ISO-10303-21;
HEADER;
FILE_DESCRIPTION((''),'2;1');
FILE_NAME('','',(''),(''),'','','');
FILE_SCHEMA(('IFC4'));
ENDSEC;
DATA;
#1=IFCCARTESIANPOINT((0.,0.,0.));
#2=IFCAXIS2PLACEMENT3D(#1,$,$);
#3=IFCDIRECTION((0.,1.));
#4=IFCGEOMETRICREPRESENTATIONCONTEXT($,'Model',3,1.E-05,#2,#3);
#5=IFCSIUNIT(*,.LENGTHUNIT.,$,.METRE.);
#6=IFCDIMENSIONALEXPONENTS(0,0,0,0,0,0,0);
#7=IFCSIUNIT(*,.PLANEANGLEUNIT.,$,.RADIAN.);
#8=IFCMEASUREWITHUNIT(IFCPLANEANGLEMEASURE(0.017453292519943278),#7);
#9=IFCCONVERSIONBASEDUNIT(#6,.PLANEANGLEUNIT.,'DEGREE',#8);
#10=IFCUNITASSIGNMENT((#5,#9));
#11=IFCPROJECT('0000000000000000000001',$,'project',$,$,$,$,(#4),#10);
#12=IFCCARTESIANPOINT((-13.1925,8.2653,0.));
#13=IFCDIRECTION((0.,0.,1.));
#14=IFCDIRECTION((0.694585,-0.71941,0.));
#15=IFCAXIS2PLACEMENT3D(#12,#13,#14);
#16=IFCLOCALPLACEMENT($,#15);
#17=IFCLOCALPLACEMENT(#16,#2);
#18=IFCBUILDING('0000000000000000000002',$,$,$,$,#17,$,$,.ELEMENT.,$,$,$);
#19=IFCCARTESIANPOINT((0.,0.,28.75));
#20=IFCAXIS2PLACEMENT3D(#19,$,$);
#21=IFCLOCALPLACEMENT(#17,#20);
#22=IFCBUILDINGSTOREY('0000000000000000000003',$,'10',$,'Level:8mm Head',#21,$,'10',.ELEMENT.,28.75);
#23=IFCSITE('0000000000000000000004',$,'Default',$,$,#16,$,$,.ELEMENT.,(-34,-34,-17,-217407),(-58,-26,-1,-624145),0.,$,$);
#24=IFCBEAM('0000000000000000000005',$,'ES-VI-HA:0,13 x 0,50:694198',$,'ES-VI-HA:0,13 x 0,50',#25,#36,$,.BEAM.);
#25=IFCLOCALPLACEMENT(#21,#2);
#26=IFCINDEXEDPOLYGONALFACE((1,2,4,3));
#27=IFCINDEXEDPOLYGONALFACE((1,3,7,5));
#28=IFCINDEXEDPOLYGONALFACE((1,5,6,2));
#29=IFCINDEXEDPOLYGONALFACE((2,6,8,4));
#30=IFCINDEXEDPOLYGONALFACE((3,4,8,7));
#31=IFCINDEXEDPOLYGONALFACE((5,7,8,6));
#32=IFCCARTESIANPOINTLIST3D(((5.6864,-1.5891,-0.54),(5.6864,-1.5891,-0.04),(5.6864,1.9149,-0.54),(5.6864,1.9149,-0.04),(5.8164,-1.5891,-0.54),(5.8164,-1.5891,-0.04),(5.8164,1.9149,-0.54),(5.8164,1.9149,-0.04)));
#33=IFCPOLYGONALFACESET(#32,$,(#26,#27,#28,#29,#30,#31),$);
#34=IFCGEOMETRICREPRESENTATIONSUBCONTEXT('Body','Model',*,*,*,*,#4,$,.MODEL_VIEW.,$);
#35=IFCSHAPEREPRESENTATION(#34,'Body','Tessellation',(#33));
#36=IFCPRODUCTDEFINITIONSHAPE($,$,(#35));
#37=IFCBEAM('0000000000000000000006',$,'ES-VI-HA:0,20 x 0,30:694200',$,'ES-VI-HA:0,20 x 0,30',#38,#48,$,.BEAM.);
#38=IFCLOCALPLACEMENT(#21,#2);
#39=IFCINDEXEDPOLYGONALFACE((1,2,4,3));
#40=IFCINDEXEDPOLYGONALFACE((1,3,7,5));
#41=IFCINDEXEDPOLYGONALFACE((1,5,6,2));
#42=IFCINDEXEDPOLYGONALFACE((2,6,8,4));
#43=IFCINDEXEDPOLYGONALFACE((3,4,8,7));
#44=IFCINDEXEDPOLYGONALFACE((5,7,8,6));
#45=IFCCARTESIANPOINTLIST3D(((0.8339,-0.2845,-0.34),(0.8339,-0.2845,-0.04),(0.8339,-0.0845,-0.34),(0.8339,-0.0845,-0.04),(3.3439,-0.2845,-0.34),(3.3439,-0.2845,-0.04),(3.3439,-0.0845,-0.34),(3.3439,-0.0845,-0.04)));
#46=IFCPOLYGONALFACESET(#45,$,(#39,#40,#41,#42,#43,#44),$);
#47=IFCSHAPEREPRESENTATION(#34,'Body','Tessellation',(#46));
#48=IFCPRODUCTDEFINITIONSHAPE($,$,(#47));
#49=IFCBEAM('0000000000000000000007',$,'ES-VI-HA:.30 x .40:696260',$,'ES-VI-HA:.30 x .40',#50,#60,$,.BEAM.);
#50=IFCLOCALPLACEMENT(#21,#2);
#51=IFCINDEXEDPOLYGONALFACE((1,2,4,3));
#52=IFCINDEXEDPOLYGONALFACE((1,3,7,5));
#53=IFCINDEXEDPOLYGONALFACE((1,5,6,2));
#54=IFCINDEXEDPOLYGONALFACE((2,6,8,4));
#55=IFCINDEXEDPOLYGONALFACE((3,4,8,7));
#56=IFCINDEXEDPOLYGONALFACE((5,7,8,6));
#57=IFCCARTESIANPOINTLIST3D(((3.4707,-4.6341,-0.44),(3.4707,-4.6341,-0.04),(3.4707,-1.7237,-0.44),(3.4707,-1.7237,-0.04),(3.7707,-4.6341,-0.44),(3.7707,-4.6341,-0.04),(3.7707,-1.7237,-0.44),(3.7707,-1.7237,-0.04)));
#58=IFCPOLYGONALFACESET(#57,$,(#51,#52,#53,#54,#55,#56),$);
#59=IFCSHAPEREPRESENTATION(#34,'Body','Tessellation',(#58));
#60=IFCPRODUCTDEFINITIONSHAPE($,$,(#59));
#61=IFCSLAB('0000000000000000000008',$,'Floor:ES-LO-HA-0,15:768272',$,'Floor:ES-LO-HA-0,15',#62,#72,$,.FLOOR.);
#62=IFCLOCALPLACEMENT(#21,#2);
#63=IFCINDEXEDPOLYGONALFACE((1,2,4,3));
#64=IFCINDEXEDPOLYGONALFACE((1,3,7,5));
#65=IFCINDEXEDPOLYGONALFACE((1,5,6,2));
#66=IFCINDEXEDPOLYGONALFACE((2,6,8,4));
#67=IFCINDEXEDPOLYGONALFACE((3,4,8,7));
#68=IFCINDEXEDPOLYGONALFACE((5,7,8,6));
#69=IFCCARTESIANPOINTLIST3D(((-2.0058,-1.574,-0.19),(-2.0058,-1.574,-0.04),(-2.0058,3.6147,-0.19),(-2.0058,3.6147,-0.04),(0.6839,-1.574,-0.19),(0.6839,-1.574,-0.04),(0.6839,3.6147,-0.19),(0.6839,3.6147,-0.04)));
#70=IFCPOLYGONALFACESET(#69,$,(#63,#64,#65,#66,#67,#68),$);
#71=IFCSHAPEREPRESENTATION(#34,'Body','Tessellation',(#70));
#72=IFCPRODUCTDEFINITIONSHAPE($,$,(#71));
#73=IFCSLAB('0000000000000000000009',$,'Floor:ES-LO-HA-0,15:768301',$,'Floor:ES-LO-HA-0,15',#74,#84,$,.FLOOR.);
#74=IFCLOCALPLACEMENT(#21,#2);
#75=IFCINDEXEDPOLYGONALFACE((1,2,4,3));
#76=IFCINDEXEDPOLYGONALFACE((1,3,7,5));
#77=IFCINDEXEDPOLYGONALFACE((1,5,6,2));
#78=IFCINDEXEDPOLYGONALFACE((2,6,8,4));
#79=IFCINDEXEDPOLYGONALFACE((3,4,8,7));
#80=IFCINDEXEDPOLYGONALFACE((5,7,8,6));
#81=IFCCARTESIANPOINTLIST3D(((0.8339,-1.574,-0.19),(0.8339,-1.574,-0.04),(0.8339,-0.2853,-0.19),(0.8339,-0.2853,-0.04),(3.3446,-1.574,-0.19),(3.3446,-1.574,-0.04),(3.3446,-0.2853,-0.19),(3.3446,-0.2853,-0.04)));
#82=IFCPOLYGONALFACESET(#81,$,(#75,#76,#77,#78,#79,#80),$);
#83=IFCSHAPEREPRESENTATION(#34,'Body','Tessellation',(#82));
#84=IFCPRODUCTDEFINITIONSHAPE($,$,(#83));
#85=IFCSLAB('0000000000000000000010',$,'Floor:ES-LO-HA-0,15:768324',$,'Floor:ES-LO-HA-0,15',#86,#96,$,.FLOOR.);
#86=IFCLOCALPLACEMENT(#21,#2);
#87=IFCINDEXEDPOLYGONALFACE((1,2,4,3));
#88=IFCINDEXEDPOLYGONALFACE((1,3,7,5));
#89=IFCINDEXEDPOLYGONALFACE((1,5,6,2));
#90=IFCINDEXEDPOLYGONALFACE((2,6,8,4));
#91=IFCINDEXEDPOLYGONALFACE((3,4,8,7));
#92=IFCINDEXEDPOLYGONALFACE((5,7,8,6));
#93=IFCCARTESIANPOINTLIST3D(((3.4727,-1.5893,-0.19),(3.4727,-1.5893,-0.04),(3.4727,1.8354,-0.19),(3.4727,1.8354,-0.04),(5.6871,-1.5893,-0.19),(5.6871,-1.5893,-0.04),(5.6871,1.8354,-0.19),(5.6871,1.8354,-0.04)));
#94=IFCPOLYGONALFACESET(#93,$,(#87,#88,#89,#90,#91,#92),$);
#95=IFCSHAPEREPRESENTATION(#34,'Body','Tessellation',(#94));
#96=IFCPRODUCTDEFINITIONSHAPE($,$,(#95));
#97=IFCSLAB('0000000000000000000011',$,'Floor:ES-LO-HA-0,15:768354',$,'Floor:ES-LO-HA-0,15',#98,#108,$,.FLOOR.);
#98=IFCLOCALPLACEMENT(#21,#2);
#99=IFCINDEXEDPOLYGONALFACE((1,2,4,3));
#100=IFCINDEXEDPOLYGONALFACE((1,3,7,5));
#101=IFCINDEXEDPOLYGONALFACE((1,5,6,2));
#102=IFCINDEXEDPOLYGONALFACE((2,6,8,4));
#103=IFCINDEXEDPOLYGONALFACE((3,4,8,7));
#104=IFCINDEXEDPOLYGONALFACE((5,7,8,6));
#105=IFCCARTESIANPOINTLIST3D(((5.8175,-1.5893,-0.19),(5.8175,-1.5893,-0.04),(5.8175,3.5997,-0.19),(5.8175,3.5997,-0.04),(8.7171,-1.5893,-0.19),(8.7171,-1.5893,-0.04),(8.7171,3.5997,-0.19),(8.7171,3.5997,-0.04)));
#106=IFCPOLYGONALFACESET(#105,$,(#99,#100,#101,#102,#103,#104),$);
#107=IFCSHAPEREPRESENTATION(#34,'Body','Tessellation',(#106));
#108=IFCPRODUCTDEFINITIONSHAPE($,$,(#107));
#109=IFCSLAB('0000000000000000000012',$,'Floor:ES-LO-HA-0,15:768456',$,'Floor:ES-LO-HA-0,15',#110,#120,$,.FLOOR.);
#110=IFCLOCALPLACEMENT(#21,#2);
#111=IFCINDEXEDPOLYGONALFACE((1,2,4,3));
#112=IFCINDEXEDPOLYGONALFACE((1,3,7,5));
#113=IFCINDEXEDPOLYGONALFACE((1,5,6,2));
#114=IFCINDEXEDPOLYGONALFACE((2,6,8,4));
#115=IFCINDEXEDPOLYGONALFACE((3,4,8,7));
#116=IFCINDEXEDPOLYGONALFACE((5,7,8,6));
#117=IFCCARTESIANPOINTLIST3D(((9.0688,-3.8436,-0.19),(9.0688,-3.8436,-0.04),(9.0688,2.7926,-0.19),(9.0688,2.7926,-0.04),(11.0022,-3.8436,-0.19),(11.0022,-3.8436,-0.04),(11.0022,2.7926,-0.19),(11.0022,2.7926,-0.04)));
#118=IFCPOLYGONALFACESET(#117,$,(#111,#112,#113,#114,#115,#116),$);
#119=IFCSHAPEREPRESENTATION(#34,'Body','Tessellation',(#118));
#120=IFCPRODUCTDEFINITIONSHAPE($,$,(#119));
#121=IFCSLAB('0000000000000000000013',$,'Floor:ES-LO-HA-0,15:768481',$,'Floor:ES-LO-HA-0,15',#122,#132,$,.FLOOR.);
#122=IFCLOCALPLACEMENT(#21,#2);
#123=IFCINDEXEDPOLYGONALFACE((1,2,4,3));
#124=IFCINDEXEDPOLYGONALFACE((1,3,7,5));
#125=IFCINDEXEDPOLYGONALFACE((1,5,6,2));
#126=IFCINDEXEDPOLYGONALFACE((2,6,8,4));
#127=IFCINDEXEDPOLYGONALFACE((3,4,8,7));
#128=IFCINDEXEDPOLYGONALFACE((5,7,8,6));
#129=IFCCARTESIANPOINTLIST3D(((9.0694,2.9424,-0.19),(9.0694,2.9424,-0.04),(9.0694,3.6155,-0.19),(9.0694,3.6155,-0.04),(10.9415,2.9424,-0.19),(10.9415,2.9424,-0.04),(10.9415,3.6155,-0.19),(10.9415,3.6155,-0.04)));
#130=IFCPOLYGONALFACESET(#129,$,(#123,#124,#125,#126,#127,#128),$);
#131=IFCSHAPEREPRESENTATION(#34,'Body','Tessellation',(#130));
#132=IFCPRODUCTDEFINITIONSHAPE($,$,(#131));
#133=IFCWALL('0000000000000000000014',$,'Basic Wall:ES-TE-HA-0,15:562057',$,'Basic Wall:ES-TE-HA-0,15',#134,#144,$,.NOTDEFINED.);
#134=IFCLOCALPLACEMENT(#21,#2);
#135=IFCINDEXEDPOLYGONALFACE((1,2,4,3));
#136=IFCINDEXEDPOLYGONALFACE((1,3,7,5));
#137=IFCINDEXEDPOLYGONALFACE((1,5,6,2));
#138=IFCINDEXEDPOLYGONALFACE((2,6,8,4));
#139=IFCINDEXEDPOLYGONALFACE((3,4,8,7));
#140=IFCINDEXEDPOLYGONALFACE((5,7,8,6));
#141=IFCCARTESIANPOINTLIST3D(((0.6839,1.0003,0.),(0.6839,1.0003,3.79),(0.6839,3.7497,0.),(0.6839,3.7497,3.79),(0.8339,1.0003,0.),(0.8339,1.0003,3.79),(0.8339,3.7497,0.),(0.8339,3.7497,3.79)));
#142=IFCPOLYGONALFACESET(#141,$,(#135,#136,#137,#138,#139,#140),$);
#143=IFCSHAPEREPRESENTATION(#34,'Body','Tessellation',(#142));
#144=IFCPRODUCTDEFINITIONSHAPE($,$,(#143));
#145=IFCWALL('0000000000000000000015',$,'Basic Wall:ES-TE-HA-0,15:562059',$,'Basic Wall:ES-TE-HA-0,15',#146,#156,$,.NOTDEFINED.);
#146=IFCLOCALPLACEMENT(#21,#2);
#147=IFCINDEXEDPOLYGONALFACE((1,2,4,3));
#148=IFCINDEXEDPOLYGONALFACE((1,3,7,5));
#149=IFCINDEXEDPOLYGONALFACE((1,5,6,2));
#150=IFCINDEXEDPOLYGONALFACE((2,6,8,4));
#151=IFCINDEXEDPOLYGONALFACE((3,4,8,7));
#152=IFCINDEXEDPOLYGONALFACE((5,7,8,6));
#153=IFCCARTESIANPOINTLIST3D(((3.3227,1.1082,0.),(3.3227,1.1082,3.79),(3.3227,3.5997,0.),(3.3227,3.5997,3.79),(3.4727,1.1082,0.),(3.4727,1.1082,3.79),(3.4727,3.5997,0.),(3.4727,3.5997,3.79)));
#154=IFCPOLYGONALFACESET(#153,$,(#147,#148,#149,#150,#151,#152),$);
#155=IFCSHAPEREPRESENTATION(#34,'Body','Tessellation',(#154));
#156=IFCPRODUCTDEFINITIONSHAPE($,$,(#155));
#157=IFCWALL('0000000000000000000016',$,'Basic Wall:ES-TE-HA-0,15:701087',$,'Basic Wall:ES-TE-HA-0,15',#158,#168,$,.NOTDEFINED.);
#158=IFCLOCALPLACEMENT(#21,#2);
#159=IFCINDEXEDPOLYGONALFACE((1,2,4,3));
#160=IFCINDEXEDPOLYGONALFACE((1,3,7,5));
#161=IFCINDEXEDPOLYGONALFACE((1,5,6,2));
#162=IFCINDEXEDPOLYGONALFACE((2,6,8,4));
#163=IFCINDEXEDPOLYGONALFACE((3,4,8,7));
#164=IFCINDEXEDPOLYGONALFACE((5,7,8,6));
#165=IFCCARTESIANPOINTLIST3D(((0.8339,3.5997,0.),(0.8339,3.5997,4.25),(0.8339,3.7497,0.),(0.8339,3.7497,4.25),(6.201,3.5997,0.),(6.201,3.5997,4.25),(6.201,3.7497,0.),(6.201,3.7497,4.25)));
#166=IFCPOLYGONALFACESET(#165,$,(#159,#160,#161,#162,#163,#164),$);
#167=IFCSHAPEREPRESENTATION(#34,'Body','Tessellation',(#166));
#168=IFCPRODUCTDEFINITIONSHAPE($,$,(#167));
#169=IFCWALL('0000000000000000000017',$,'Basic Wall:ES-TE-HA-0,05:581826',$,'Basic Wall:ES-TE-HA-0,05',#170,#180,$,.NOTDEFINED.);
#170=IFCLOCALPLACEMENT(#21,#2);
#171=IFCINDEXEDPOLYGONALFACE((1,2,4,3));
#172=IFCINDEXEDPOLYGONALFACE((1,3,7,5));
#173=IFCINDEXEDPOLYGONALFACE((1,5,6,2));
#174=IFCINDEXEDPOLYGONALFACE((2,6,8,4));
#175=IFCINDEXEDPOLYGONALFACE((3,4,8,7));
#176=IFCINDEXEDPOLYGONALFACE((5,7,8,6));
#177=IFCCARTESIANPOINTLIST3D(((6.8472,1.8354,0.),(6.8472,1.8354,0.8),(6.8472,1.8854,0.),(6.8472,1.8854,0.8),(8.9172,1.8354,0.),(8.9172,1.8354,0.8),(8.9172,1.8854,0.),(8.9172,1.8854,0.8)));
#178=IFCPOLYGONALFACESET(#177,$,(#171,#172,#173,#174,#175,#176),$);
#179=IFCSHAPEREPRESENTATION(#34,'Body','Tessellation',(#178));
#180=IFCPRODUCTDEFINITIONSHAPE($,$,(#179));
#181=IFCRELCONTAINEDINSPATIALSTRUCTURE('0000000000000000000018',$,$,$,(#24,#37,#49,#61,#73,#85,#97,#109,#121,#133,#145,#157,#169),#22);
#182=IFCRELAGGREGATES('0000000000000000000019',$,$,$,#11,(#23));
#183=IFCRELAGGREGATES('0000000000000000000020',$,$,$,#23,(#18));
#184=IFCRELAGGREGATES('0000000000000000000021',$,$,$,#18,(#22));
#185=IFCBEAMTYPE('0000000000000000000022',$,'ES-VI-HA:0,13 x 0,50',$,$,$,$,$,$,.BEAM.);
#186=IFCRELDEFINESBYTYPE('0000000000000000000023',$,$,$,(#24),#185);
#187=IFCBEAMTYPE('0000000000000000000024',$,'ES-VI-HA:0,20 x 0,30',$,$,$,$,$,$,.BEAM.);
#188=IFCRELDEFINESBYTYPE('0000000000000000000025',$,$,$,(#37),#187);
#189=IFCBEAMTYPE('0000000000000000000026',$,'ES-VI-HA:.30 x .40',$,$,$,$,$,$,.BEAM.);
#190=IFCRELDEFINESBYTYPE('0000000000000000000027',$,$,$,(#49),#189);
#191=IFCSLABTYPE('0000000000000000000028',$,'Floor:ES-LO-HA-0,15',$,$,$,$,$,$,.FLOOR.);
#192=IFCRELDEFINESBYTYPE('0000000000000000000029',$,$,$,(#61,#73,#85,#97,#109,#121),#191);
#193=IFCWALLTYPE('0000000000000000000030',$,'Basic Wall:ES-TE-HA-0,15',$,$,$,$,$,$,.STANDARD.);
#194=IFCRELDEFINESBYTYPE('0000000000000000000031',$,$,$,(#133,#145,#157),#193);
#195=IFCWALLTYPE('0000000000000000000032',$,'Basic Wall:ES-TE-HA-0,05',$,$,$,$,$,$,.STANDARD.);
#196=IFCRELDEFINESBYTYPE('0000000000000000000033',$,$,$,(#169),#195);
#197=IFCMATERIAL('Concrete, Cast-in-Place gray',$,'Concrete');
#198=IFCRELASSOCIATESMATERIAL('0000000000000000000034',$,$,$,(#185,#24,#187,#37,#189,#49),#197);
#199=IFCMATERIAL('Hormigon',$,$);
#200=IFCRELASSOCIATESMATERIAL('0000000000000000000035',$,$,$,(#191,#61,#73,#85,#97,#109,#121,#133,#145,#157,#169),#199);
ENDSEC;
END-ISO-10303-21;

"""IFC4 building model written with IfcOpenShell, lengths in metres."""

from ifc_helpers import new_model, entity, si_unit, converted_unit, direction, frame, origin, place, context, subcontext, project, spatial, indexed_curve, outline, extrude, source, transform, mapped, material, type_object, type_shapes, element, save


model = new_model("IFC4")

# Units and contexts
model_context = context("Model", 3, precision=1e-05, world=origin(), true_north=direction((0.0, 1.0)))
body_context = subcontext(model_context, "Body", "Model", "MODEL_VIEW")
ifc_project = project(units=[si_unit("LENGTHUNIT", "METRE"), converted_unit("PLANEANGLEUNIT", "DEGREE", entity("IfcPlaneAngleMeasure", 0.017453292519943278), si_unit("PLANEANGLEUNIT", "RADIAN"), dimensions=[0, 0, 0, 0, 0, 0, 0])], contexts=[model_context])

# Site, building, storey
site_placement = place(None, frame((-13.1925, 8.2653, 0.0), z_axis=(0.0, 0.0, 1.0), x_axis=(0.694585, -0.71941, 0.0)))
site = spatial("IfcSite", under=ifc_project, at=site_placement, Name="Default", CompositionType="ELEMENT", RefLatitude=(-34, -34, -17, -217407), RefLongitude=(-58, -26, -1, -624145), RefElevation=0.0)
building_placement = place(site_placement, origin())
building = spatial("IfcBuilding", under=site, at=building_placement, CompositionType="ELEMENT")
storey_placement = place(building_placement, frame((0.0, 0.0, 28.75)))
storey = spatial("IfcBuildingStorey", under=building, at=storey_placement, Name="10", ObjectType="Level:8mm Head", LongName="10", CompositionType="ELEMENT", Elevation=28.75)

# Beams
ifc_material_1 = material(Name="Concrete, Cast-in-Place gray", Category="Concrete")
beam_type_1 = type_object("IfcBeamType", Name="ES-VI-HA:0,13 x 0,50", PredefinedType="BEAM", material=ifc_material_1)
shared_shape_1 = source(origin(), body_context, "Body", "SweptSolid", [
    extrude(outline(indexed_curve([(-0.065, -0.25), (0.065, -0.25), (0.065, 0.25), (-0.065, 0.25), (-0.065, -0.25)], self_intersect=False)), frame((5.7514, -1.5891, 28.46), z_axis=(0.0, 1.0, 0.0), x_axis=(-1.0, 0.0, 0.0)), (0.0, 0.0, 1.0), 3.5039),
])
type_shapes(beam_type_1, [shared_shape_1])
beam_1_placement = place(storey_placement, frame((0.0, 0.0, -28.75)))
element("IfcBeam", 1, at=beam_1_placement, inside=storey, type_object=beam_type_1, material=ifc_material_1, Name="ES-VI-HA:0,13 x 0,50:694198", ObjectType="ES-VI-HA:0,13 x 0,50", PredefinedType="BEAM", context=body_context, shape_type="MappedRepresentation", body=[
    mapped(shared_shape_1, transform((0.0, 0.0, 0.0), scale=1.0)),
])
beam_type_2 = type_object("IfcBeamType", Name="ES-VI-HA:0,20 x 0,30", PredefinedType="BEAM", material=ifc_material_1)
shared_shape_2 = source(origin(), body_context, "Body", "SweptSolid", [
    extrude(outline(indexed_curve([(-0.15, -0.1), (0.15, -0.1), (0.15, 0.1), (-0.15, 0.1), (-0.15, -0.1)], self_intersect=False)), frame((0.8339, -0.1845, 28.56), z_axis=(1.0, 0.0, 0.0), x_axis=(0.0, 0.0, -1.0)), (0.0, 0.0, 1.0), 2.51),
])
type_shapes(beam_type_2, [shared_shape_2])
beam_2_placement = place(storey_placement, frame((0.0, 0.0, -28.75)))
element("IfcBeam", 2, at=beam_2_placement, inside=storey, type_object=beam_type_2, material=ifc_material_1, Name="ES-VI-HA:0,20 x 0,30:694200", ObjectType="ES-VI-HA:0,20 x 0,30", PredefinedType="BEAM", context=body_context, shape_type="MappedRepresentation", body=[
    mapped(shared_shape_2, transform((0.0, 0.0, 0.0), scale=1.0)),
])
beam_type_3 = type_object("IfcBeamType", Name="ES-VI-HA:.30 x .40", PredefinedType="BEAM", material=ifc_material_1)
shared_shape_3 = source(origin(), body_context, "Body", "SweptSolid", [
    extrude(outline(indexed_curve([(-0.15, -0.2), (0.15, -0.2), (0.15, 0.2), (-0.15, 0.2), (-0.15, -0.2)], self_intersect=False)), frame((3.6207, -4.6341, 28.51), z_axis=(0.0, 1.0, 0.0), x_axis=(-1.0, 0.0, 0.0)), (0.0, 0.0, 1.0), 2.9104),
])
type_shapes(beam_type_3, [shared_shape_3])
beam_3_placement = place(storey_placement, frame((0.0, 0.0, -28.75)))
element("IfcBeam", 3, at=beam_3_placement, inside=storey, type_object=beam_type_3, material=ifc_material_1, Name="ES-VI-HA:.30 x .40:696260", ObjectType="ES-VI-HA:.30 x .40", PredefinedType="BEAM", context=body_context, shape_type="MappedRepresentation", body=[
    mapped(shared_shape_3, transform((0.0, 0.0, 0.0), scale=1.0)),
])

# Slabs
ifc_material_2 = material(Name="Hormigon")
slab_type = type_object("IfcSlabType", Name="Floor:ES-LO-HA-0,15", PredefinedType="FLOOR", material=ifc_material_2)
slab_1_placement = place(storey_placement, origin())
element("IfcSlab", 4, at=slab_1_placement, inside=storey, type_object=slab_type, material=ifc_material_2, Name="Floor:ES-LO-HA-0,15:768272", ObjectType="Floor:ES-LO-HA-0,15", PredefinedType="FLOOR", context=body_context, shape_type="SweptSolid", body=[
    extrude(outline(indexed_curve([(-2.5943, -1.3449), (2.5943, -1.3449), (2.5943, 1.3449), (-2.5943, 1.3449), (-2.5943, -1.3449)], self_intersect=False)), frame((-0.6609, 1.0203, -0.04), z_axis=(0.0, 0.0, -1.0), x_axis=(0.0, 1.0, 0.0)), (0.0, 0.0, 1.0), 0.15),
])
slab_2_placement = place(storey_placement, origin())
element("IfcSlab", 5, at=slab_2_placement, inside=storey, type_object=slab_type, material=ifc_material_2, Name="Floor:ES-LO-HA-0,15:768301", ObjectType="Floor:ES-LO-HA-0,15", PredefinedType="FLOOR", context=body_context, shape_type="SweptSolid", body=[
    extrude(outline(indexed_curve([(-0.6443, -1.2553), (0.6443, -1.2553), (0.6443, 1.2553), (-0.6443, 1.2553), (-0.6443, -1.2553)], self_intersect=False)), frame((2.0893, -0.9297, -0.04), z_axis=(0.0, 0.0, -1.0), x_axis=(0.0, 1.0, 0.0)), (0.0, 0.0, 1.0), 0.15),
])
slab_3_placement = place(storey_placement, origin())
element("IfcSlab", 6, at=slab_3_placement, inside=storey, type_object=slab_type, material=ifc_material_2, Name="Floor:ES-LO-HA-0,15:768324", ObjectType="Floor:ES-LO-HA-0,15", PredefinedType="FLOOR", context=body_context, shape_type="SweptSolid", body=[
    extrude(outline(indexed_curve([(-1.7124, -1.1072), (1.7124, -1.1072), (1.7124, 1.1072), (-1.7124, 1.1072), (-1.7124, -1.1072)], self_intersect=False)), frame((4.5799, 0.1231, -0.04), z_axis=(0.0, 0.0, -1.0), x_axis=(0.0, 1.0, 0.0)), (0.0, 0.0, 1.0), 0.15),
])
slab_4_placement = place(storey_placement, origin())
element("IfcSlab", 7, at=slab_4_placement, inside=storey, type_object=slab_type, material=ifc_material_2, Name="Floor:ES-LO-HA-0,15:768354", ObjectType="Floor:ES-LO-HA-0,15", PredefinedType="FLOOR", context=body_context, shape_type="SweptSolid", body=[
    extrude(outline(indexed_curve([(-2.5945, -1.4498), (2.5945, -1.4498), (2.5945, 1.4498), (-2.5945, 1.4498), (-2.5945, -1.4498)], self_intersect=False)), frame((7.2673, 1.0052, -0.04), z_axis=(0.0, 0.0, -1.0), x_axis=(0.0, 1.0, 0.0)), (0.0, 0.0, 1.0), 0.15),
])
slab_5_placement = place(storey_placement, origin())
element("IfcSlab", 8, at=slab_5_placement, inside=storey, type_object=slab_type, material=ifc_material_2, Name="Floor:ES-LO-HA-0,15:768456", ObjectType="Floor:ES-LO-HA-0,15", PredefinedType="FLOOR", context=body_context, shape_type="SweptSolid", body=[
    extrude(outline(indexed_curve([(-3.3181, -0.9667), (3.3181, -0.9667), (3.3181, 0.9667), (-3.3181, 0.9667), (-3.3181, -0.9667)], self_intersect=False)), frame((10.0355, -0.5255, -0.04), z_axis=(0.0, 0.0, -1.0), x_axis=(0.0, 1.0, 0.0)), (0.0, 0.0, 1.0), 0.15),
])
slab_6_placement = place(storey_placement, origin())
element("IfcSlab", 9, at=slab_6_placement, inside=storey, type_object=slab_type, material=ifc_material_2, Name="Floor:ES-LO-HA-0,15:768481", ObjectType="Floor:ES-LO-HA-0,15", PredefinedType="FLOOR", context=body_context, shape_type="SweptSolid", body=[
    extrude(outline(indexed_curve([(-0.3365, -0.936), (0.3365, -0.936), (0.3365, 0.936), (-0.3365, 0.936), (-0.3365, -0.936)], self_intersect=False)), frame((10.0055, 3.2789, -0.04), z_axis=(0.0, 0.0, -1.0), x_axis=(0.0, 1.0, 0.0)), (0.0, 0.0, 1.0), 0.15),
])

# Walls
wall_type_1 = type_object("IfcWallType", Name="Basic Wall:ES-TE-HA-0,15", PredefinedType="STANDARD")
wall_1_placement = place(storey_placement, frame((0.7589, 1.0003, 0.0), z_axis=(0.0, 0.0, 1.0), x_axis=(0.0, 1.0, 0.0)))
element("IfcWall", 10, at=wall_1_placement, inside=storey, type_object=wall_type_1, material=ifc_material_2, Name="Basic Wall:ES-TE-HA-0,15:562057", ObjectType="Basic Wall:ES-TE-HA-0,15", PredefinedType="NOTDEFINED", context=body_context, shape_type="SweptSolid", body=[
    extrude(outline(indexed_curve([(2.7494, 0.075), (0.0, 0.075), (0.0, -0.075), (2.7494, -0.075), (2.7494, 0.075)], self_intersect=False)), origin(), (0.0, 0.0, 1.0), 3.79),
])
wall_2_placement = place(storey_placement, frame((3.3977, 3.5997, 0.0), z_axis=(0.0, 0.0, 1.0), x_axis=(0.0, -1.0, 0.0)))
element("IfcWall", 11, at=wall_2_placement, inside=storey, type_object=wall_type_1, material=ifc_material_2, Name="Basic Wall:ES-TE-HA-0,15:562059", ObjectType="Basic Wall:ES-TE-HA-0,15", PredefinedType="NOTDEFINED", context=body_context, shape_type="SweptSolid", body=[
    extrude(outline(indexed_curve([(2.4914, 0.075), (0.0, 0.075), (0.0, -0.075), (2.4914, -0.075), (2.4914, 0.075)], self_intersect=False)), origin(), (0.0, 0.0, 1.0), 3.79),
])
wall_3_placement = place(storey_placement, frame((0.8339, 3.6747, 0.0)))
element("IfcWall", 12, at=wall_3_placement, inside=storey, type_object=wall_type_1, material=ifc_material_2, Name="Basic Wall:ES-TE-HA-0,15:701087", ObjectType="Basic Wall:ES-TE-HA-0,15", PredefinedType="NOTDEFINED", context=body_context, shape_type="SweptSolid", body=[
    extrude(outline(indexed_curve([(5.367, 0.075), (0.0, 0.075), (0.0, -0.075), (5.367, -0.075), (5.367, 0.075)], self_intersect=False)), origin(), (0.0, 0.0, 1.0), 4.25),
])
wall_type_2 = type_object("IfcWallType", Name="Basic Wall:ES-TE-HA-0,05", PredefinedType="STANDARD")
wall_4_placement = place(storey_placement, frame((6.8472, 1.8604, 0.0)))
element("IfcWall", 13, at=wall_4_placement, inside=storey, type_object=wall_type_2, material=ifc_material_2, Name="Basic Wall:ES-TE-HA-0,05:581826", ObjectType="Basic Wall:ES-TE-HA-0,05", PredefinedType="NOTDEFINED", context=body_context, shape_type="SweptSolid", body=[
    extrude(outline(indexed_curve([(2.07, 0.025), (0.0, 0.025), (0.0, -0.025), (2.07, -0.025), (2.07, 0.025)], self_intersect=False)), origin(), (0.0, 0.0, 1.0), 0.8),
])

save(model, "model.ifc")
